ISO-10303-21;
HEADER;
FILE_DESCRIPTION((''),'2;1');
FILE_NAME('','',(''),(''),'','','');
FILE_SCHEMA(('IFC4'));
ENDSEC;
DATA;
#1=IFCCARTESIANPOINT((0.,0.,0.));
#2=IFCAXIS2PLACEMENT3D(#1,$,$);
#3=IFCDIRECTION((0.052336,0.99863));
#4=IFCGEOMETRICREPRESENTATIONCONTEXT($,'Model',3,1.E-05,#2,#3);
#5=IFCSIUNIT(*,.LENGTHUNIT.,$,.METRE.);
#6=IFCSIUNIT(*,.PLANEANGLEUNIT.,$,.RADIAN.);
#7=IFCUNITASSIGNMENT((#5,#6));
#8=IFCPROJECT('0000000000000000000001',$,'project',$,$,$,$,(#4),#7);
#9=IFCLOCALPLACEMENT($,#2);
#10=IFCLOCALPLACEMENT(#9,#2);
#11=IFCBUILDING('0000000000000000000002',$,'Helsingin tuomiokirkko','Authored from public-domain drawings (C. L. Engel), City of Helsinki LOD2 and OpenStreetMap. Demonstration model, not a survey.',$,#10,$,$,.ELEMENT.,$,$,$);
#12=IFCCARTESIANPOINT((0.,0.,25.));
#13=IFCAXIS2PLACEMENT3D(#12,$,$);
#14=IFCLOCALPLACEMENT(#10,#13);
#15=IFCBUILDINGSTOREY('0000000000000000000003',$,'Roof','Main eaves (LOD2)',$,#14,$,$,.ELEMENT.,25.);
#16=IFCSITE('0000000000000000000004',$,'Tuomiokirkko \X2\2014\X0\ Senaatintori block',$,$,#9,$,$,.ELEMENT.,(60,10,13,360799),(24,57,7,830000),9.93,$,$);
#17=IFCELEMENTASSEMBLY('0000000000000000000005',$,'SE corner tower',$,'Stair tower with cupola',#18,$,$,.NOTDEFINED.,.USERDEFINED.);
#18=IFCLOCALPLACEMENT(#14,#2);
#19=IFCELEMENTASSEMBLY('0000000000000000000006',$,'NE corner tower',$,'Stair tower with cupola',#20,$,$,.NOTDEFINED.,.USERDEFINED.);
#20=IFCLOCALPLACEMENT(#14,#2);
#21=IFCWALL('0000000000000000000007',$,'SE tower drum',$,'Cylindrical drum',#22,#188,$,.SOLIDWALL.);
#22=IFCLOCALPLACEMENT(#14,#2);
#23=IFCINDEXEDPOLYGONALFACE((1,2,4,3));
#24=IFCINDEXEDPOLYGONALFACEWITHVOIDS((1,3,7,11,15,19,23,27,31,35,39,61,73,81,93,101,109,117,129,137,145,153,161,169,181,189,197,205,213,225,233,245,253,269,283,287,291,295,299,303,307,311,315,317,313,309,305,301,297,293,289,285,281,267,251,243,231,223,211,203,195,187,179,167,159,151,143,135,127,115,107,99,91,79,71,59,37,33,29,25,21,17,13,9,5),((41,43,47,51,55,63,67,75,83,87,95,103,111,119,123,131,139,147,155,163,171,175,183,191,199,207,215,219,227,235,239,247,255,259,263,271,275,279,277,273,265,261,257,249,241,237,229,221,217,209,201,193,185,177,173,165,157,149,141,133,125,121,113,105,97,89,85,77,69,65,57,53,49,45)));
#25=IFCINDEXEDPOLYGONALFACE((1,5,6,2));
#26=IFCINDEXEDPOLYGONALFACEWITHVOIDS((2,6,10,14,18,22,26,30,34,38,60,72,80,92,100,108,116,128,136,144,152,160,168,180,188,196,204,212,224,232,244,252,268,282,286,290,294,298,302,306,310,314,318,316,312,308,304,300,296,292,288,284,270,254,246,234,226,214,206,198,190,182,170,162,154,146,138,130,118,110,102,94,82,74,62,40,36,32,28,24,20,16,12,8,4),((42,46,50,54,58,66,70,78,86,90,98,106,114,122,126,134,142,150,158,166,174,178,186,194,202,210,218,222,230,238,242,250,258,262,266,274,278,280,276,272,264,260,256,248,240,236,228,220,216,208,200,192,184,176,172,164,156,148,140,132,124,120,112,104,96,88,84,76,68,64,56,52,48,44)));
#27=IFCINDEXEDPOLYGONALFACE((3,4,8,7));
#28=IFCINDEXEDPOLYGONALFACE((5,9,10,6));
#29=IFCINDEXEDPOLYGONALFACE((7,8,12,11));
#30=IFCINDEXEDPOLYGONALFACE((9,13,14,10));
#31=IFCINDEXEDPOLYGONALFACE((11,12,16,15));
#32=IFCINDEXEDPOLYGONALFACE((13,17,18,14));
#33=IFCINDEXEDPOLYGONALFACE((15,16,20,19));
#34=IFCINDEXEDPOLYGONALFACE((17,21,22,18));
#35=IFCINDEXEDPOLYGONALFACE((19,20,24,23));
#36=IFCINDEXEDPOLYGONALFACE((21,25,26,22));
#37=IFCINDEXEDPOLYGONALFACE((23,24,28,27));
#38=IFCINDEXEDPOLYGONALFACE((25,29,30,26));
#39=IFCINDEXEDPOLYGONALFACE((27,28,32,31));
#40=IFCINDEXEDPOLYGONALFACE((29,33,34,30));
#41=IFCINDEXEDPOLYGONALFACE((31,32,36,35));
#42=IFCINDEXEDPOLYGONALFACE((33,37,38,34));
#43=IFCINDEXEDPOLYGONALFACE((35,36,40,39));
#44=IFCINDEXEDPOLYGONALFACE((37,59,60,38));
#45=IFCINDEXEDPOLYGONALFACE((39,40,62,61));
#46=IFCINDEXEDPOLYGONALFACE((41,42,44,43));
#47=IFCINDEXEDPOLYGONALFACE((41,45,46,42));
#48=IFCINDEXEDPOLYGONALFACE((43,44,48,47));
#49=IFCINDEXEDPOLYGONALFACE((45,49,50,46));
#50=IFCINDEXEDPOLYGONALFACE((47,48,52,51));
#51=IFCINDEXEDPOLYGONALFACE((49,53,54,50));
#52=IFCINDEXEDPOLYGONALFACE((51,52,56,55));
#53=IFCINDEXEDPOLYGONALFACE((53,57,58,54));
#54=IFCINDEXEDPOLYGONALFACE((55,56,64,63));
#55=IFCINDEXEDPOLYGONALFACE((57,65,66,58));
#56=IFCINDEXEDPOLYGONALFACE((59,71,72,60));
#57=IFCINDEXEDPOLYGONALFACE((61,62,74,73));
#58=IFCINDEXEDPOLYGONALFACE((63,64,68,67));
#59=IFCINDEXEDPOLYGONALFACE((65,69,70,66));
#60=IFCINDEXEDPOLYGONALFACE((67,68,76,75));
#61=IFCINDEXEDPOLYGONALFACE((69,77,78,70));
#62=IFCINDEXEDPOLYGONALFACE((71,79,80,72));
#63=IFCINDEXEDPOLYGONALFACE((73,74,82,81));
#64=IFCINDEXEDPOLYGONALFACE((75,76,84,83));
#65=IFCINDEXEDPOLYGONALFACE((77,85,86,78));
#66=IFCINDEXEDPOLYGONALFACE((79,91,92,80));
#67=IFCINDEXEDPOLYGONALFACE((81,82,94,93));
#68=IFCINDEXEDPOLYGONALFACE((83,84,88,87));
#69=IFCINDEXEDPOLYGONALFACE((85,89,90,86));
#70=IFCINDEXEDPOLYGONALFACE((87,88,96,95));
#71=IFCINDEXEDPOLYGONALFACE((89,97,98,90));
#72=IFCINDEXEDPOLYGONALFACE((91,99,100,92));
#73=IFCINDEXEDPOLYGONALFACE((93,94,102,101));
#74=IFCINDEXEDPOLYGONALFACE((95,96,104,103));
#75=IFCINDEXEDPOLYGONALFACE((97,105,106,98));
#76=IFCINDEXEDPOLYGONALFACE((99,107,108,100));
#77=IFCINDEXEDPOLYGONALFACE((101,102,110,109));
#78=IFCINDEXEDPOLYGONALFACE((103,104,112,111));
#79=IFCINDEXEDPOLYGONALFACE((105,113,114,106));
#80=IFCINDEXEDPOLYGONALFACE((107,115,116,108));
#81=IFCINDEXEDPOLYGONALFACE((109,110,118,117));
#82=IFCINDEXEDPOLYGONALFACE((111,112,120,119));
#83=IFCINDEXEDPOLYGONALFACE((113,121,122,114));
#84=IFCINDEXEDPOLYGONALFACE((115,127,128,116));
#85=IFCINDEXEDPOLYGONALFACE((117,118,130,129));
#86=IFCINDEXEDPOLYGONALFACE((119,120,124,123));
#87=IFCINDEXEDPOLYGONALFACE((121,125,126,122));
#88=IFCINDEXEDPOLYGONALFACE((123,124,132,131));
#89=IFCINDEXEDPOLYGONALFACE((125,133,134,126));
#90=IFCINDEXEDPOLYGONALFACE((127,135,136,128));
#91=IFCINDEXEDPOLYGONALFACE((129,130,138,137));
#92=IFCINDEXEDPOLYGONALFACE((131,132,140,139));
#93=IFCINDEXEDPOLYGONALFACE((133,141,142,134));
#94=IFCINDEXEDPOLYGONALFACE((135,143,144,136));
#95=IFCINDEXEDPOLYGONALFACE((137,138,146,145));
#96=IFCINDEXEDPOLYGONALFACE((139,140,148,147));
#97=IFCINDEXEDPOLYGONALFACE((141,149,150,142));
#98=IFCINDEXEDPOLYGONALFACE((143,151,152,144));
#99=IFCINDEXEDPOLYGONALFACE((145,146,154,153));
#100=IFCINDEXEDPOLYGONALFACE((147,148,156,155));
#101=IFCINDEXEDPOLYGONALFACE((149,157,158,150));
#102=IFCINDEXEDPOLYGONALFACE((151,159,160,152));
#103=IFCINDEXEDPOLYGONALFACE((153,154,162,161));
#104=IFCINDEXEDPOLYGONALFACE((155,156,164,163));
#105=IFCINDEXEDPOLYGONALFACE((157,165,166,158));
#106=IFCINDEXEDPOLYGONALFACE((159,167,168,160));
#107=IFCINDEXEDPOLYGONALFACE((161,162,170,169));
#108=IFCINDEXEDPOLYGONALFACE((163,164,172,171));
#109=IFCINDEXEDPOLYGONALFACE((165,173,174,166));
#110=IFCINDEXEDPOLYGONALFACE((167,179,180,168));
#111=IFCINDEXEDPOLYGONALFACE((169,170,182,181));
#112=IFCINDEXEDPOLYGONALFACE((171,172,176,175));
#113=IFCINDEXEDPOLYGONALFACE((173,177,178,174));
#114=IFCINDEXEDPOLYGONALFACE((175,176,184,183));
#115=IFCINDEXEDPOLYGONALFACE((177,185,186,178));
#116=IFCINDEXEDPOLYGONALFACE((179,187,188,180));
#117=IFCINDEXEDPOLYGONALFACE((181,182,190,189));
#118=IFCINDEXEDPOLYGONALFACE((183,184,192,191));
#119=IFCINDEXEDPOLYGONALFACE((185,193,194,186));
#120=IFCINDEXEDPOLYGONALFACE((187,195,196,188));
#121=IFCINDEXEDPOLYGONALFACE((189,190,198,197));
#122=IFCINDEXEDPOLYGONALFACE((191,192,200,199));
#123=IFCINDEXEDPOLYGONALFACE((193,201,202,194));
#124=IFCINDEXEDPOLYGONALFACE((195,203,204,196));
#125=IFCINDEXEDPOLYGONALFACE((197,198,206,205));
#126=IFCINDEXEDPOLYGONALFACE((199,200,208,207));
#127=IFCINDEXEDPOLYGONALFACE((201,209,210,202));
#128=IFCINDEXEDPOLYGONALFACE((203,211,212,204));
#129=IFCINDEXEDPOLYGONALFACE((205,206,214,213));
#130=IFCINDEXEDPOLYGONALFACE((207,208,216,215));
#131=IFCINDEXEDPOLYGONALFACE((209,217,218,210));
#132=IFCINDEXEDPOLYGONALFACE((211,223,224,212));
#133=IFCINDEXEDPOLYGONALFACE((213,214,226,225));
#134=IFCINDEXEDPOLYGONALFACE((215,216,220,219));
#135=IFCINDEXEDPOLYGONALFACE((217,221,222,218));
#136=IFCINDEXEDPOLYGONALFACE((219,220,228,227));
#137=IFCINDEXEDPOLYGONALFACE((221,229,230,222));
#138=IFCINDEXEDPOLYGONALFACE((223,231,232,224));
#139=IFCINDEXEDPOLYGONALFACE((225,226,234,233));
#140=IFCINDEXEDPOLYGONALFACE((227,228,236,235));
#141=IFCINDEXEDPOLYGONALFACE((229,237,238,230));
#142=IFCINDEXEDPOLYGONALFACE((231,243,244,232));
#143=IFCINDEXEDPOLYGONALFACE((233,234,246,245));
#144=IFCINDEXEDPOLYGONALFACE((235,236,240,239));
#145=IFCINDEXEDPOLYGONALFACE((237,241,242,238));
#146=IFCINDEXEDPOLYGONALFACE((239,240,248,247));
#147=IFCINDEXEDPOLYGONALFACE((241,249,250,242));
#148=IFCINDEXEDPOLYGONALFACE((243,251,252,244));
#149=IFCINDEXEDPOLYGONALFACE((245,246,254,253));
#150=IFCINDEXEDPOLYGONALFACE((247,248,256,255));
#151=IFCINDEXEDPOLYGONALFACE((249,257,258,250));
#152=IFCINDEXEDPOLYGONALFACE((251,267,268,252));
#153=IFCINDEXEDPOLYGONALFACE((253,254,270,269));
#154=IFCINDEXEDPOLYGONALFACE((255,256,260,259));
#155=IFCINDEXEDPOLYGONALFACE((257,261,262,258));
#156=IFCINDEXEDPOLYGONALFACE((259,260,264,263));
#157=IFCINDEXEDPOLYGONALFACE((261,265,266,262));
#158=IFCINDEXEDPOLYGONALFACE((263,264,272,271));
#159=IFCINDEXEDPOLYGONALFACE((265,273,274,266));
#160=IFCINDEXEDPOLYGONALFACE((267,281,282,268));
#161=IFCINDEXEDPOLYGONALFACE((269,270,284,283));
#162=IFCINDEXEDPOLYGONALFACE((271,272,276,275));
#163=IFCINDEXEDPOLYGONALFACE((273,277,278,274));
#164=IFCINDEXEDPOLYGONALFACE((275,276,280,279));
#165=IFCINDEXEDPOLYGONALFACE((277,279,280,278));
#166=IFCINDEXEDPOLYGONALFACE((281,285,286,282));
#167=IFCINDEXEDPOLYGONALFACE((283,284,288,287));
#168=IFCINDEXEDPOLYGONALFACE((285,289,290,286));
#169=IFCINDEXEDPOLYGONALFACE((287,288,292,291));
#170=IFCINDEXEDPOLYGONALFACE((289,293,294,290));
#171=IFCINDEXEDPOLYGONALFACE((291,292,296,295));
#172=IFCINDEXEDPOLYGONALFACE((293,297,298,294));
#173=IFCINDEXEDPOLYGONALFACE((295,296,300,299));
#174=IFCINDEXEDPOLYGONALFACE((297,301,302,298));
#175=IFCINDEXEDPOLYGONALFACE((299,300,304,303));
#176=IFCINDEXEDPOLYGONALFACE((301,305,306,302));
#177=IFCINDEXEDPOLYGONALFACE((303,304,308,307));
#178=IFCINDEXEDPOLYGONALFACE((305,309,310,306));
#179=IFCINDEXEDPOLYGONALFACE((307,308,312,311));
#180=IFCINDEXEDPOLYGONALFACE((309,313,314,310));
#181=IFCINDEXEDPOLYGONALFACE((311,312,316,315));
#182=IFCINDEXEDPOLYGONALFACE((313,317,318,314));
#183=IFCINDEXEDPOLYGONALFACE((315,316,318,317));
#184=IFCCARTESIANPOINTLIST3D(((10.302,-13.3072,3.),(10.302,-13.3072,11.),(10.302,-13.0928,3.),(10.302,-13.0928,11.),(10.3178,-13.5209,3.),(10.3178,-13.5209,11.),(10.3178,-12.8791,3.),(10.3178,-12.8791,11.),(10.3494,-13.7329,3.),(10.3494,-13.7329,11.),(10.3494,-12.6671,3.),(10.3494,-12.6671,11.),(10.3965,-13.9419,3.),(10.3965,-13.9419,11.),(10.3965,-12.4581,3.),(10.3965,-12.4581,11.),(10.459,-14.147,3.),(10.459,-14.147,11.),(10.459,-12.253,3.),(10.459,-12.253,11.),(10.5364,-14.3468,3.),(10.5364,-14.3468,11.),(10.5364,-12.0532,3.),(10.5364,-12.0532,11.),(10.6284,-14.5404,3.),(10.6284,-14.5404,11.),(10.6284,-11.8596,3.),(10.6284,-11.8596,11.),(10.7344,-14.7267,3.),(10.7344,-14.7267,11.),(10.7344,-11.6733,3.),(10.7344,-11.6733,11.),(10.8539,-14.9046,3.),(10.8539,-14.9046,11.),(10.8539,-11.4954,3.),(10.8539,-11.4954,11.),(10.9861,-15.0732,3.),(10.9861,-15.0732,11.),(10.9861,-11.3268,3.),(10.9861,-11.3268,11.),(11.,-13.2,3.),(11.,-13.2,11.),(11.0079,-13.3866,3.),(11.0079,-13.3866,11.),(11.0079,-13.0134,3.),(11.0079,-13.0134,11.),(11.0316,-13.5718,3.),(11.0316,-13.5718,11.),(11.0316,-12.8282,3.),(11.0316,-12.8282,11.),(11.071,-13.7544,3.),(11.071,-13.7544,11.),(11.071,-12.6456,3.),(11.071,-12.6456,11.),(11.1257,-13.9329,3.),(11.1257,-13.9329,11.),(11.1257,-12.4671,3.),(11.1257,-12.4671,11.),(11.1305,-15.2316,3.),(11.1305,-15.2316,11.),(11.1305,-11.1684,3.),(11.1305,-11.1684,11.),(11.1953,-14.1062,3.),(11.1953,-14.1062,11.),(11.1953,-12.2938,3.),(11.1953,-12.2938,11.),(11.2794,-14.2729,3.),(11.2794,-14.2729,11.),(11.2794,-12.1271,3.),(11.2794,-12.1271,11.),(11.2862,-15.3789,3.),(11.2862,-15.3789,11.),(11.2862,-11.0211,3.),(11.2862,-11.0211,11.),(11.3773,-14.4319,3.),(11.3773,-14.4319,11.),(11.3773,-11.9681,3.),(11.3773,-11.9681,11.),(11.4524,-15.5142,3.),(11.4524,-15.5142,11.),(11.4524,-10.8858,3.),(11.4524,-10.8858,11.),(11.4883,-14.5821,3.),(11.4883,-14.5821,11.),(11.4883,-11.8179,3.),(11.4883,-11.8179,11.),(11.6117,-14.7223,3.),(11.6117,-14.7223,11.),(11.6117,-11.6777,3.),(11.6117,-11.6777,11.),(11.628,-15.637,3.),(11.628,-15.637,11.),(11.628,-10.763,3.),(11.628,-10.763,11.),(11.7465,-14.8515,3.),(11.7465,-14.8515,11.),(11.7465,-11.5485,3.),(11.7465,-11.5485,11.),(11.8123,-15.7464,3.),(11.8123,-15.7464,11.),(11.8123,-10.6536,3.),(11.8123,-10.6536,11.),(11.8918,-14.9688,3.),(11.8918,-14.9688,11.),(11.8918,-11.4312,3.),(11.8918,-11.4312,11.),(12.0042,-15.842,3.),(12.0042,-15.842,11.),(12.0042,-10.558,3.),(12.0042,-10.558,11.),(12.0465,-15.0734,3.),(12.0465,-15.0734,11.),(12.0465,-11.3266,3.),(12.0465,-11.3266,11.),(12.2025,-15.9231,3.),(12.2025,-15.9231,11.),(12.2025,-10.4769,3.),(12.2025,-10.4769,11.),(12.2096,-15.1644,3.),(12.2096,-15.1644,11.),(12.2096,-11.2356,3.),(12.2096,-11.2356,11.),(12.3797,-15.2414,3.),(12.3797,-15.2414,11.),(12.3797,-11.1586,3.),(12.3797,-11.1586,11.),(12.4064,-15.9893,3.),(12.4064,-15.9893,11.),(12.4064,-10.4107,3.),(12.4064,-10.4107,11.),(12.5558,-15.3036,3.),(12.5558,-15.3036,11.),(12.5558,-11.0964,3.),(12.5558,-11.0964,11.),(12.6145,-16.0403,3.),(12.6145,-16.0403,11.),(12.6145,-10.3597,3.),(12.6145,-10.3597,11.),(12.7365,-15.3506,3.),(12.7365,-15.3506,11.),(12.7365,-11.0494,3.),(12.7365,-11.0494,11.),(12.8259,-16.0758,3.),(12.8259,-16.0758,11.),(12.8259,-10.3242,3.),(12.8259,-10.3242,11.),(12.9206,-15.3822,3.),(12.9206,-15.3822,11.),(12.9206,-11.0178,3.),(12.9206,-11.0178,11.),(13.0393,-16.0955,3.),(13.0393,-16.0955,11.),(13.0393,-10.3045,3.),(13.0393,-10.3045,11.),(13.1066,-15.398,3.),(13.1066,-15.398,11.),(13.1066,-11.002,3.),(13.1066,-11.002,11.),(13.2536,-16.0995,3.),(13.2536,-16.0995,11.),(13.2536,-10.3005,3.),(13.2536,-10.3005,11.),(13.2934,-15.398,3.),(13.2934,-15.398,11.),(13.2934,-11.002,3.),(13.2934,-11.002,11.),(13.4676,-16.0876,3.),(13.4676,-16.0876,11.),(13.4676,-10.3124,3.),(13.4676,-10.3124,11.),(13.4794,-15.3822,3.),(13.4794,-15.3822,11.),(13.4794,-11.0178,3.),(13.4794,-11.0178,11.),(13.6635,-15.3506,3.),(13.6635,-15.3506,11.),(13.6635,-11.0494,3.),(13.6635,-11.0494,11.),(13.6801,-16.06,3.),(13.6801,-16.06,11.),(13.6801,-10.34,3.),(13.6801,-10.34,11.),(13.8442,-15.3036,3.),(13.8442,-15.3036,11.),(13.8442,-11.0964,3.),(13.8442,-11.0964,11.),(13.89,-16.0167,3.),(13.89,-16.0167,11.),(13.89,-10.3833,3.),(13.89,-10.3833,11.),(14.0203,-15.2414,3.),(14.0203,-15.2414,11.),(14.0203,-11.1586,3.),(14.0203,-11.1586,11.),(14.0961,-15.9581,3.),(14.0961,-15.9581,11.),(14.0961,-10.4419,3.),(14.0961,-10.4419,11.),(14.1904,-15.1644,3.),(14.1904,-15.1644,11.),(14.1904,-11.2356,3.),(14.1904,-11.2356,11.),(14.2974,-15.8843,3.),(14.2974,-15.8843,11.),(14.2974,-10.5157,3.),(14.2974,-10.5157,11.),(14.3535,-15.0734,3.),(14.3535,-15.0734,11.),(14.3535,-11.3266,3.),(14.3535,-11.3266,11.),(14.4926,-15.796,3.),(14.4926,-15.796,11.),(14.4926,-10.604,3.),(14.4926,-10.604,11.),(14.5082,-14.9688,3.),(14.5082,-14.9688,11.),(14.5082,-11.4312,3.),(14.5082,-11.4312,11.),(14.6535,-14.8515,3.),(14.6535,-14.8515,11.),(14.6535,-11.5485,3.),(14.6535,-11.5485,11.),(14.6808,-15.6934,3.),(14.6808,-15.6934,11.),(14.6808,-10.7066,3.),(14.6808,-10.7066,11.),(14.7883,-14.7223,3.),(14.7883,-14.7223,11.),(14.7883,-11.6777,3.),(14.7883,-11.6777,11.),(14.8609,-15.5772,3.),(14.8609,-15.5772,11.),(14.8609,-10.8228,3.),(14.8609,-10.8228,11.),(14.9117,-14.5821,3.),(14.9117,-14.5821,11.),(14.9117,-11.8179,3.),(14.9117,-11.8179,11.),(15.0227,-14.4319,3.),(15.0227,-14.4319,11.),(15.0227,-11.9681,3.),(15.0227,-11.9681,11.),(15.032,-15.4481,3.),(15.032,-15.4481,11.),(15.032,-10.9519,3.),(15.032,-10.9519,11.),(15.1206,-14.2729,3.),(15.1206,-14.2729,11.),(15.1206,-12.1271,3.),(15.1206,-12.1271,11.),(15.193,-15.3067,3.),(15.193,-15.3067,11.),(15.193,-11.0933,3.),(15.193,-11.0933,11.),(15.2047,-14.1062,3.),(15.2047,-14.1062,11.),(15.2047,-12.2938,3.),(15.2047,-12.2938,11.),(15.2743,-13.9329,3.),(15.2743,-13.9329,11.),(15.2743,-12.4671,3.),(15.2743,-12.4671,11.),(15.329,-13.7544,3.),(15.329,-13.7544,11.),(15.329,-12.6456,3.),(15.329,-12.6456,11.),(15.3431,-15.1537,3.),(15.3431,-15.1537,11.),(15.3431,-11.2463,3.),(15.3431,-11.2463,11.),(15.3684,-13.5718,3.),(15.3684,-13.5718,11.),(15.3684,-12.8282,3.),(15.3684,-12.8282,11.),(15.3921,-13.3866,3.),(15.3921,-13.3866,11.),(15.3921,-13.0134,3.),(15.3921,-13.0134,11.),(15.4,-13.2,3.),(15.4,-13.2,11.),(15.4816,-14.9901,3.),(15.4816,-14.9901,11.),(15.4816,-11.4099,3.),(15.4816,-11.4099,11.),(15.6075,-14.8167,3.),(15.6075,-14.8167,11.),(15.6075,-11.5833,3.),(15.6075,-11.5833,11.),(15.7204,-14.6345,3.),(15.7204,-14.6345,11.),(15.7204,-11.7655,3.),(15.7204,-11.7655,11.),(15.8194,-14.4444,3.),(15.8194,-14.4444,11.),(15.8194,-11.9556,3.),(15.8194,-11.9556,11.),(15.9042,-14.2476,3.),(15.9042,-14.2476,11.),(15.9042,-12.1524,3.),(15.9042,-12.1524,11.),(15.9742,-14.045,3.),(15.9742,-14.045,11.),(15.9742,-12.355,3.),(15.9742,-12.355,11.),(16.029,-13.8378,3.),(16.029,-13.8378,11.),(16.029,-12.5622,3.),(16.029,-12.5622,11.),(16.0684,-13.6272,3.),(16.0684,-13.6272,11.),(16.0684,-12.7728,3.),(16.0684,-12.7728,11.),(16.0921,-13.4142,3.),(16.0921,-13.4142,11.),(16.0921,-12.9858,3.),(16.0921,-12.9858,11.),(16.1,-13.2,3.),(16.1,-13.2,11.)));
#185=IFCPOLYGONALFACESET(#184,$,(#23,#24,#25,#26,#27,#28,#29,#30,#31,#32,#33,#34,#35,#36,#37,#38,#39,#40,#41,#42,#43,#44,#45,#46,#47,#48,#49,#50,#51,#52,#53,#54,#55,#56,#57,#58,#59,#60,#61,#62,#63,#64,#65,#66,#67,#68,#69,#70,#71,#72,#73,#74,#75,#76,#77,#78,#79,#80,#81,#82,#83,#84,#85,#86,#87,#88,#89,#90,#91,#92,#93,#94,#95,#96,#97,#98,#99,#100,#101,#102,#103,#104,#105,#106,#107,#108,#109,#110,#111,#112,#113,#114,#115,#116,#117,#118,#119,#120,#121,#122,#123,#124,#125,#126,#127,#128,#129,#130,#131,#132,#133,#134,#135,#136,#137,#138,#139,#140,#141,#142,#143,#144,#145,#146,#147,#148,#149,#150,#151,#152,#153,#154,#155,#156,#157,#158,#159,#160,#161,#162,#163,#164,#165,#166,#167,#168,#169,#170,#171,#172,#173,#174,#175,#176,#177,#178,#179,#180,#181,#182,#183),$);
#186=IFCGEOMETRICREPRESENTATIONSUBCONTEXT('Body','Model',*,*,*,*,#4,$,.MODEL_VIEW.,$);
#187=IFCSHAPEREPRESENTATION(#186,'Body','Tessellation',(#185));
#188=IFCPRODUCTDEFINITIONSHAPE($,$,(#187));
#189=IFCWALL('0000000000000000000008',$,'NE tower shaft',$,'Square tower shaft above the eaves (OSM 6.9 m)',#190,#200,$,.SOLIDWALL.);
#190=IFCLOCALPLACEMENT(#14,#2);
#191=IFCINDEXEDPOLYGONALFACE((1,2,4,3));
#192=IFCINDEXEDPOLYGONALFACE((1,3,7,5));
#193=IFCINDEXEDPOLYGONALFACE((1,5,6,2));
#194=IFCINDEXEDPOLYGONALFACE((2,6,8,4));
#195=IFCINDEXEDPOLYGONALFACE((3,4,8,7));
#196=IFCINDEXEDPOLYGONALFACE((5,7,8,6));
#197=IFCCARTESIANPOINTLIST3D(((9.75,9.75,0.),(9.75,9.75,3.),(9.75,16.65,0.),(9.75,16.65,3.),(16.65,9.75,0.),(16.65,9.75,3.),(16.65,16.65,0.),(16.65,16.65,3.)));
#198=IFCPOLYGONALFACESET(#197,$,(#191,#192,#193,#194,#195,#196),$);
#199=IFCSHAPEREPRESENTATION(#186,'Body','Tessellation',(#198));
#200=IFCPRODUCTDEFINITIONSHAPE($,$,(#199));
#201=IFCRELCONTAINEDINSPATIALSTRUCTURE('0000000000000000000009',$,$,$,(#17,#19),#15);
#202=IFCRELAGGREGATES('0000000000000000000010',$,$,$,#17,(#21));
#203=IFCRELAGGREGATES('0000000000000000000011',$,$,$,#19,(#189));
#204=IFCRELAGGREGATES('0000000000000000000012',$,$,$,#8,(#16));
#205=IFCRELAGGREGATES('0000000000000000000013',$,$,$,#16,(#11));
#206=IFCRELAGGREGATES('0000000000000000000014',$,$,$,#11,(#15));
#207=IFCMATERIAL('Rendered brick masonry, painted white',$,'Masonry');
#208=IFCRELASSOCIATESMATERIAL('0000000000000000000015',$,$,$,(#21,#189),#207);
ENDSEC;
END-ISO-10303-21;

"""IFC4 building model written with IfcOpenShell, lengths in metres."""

from ifc_helpers import new_model, si_unit, direction, frame, origin, origin_2d_with_axis, place, context, subcontext, project, spatial, rectangle, hollow_circle, extrude, material, element, aggregate, save


model = new_model("IFC4")

# Units and contexts
model_context = context("Model", 3, precision=1e-05, world=origin(), true_north=direction((0.052336, 0.99863)))
body_context = subcontext(model_context, "Body", "Model", "MODEL_VIEW")
ifc_project = project(units=[si_unit("LENGTHUNIT", "METRE"), si_unit("PLANEANGLEUNIT", "RADIAN")], contexts=[model_context])

# Site, building, storey
site_placement = place(None, origin())
site = spatial("IfcSite", under=ifc_project, at=site_placement, Name="Tuomiokirkko — Senaatintori block", CompositionType="ELEMENT", RefLatitude=(60, 10, 13, 360799), RefLongitude=(24, 57, 7, 830000), RefElevation=9.93)
building_placement = place(site_placement, origin())
building = spatial("IfcBuilding", under=site, at=building_placement, Name="Helsingin tuomiokirkko", Description="Authored from public-domain drawings (C. L. Engel), City of Helsinki LOD2 and OpenStreetMap. Demonstration model, not a survey.", CompositionType="ELEMENT")
storey_placement = place(building_placement, frame((0.0, 0.0, 25.0)))
storey = spatial("IfcBuildingStorey", under=building, at=storey_placement, Name="Roof", Description="Main eaves (LOD2)", CompositionType="ELEMENT", Elevation=25.0)

# Element assemblies
assembly_1_placement = place(building_placement, origin())
assembly_1 = element("IfcElementAssembly", 1, at=assembly_1_placement, inside=storey, Name="SE corner tower", ObjectType="Stair tower with cupola", AssemblyPlace="NOTDEFINED", PredefinedType="USERDEFINED")
assembly_2_placement = place(building_placement, origin())
assembly_2 = element("IfcElementAssembly", 2, at=assembly_2_placement, inside=storey, Name="NE corner tower", ObjectType="Stair tower with cupola", AssemblyPlace="NOTDEFINED", PredefinedType="USERDEFINED")

# Shared definitions
ifc_material_1 = material(Name="Rendered brick masonry, painted white", Category="Masonry")

# Walls
wall_1_placement = place(building_placement, origin())
wall_1 = element("IfcWall", 3, at=wall_1_placement, material=ifc_material_1, Name="SE tower drum", ObjectType="Cylindrical drum", PredefinedType="SOLIDWALL", context=body_context, shape_type="SweptSolid", body=[
    extrude(hollow_circle(Radius=2.9, WallThickness=0.7, at=origin_2d_with_axis()), frame((13.2, -13.2, 28.0)), (0.0, 0.0, 1.0), 8.0),
])
wall_2_placement = place(building_placement, origin())
wall_2 = element("IfcWall", 4, at=wall_2_placement, material=ifc_material_1, Name="NE tower shaft", ObjectType="Square tower shaft above the eaves (OSM 6.9 m)", PredefinedType="SOLIDWALL", context=body_context, shape_type="SweptSolid", body=[
    extrude(rectangle(XDim=6.9, YDim=6.9, at=origin_2d_with_axis()), frame((13.2, 13.2, 25.0)), (0.0, 0.0, 1.0), 3.0),
])

aggregate(assembly_1, [wall_1])
aggregate(assembly_2, [wall_2])

save(model, "model.ifc")
